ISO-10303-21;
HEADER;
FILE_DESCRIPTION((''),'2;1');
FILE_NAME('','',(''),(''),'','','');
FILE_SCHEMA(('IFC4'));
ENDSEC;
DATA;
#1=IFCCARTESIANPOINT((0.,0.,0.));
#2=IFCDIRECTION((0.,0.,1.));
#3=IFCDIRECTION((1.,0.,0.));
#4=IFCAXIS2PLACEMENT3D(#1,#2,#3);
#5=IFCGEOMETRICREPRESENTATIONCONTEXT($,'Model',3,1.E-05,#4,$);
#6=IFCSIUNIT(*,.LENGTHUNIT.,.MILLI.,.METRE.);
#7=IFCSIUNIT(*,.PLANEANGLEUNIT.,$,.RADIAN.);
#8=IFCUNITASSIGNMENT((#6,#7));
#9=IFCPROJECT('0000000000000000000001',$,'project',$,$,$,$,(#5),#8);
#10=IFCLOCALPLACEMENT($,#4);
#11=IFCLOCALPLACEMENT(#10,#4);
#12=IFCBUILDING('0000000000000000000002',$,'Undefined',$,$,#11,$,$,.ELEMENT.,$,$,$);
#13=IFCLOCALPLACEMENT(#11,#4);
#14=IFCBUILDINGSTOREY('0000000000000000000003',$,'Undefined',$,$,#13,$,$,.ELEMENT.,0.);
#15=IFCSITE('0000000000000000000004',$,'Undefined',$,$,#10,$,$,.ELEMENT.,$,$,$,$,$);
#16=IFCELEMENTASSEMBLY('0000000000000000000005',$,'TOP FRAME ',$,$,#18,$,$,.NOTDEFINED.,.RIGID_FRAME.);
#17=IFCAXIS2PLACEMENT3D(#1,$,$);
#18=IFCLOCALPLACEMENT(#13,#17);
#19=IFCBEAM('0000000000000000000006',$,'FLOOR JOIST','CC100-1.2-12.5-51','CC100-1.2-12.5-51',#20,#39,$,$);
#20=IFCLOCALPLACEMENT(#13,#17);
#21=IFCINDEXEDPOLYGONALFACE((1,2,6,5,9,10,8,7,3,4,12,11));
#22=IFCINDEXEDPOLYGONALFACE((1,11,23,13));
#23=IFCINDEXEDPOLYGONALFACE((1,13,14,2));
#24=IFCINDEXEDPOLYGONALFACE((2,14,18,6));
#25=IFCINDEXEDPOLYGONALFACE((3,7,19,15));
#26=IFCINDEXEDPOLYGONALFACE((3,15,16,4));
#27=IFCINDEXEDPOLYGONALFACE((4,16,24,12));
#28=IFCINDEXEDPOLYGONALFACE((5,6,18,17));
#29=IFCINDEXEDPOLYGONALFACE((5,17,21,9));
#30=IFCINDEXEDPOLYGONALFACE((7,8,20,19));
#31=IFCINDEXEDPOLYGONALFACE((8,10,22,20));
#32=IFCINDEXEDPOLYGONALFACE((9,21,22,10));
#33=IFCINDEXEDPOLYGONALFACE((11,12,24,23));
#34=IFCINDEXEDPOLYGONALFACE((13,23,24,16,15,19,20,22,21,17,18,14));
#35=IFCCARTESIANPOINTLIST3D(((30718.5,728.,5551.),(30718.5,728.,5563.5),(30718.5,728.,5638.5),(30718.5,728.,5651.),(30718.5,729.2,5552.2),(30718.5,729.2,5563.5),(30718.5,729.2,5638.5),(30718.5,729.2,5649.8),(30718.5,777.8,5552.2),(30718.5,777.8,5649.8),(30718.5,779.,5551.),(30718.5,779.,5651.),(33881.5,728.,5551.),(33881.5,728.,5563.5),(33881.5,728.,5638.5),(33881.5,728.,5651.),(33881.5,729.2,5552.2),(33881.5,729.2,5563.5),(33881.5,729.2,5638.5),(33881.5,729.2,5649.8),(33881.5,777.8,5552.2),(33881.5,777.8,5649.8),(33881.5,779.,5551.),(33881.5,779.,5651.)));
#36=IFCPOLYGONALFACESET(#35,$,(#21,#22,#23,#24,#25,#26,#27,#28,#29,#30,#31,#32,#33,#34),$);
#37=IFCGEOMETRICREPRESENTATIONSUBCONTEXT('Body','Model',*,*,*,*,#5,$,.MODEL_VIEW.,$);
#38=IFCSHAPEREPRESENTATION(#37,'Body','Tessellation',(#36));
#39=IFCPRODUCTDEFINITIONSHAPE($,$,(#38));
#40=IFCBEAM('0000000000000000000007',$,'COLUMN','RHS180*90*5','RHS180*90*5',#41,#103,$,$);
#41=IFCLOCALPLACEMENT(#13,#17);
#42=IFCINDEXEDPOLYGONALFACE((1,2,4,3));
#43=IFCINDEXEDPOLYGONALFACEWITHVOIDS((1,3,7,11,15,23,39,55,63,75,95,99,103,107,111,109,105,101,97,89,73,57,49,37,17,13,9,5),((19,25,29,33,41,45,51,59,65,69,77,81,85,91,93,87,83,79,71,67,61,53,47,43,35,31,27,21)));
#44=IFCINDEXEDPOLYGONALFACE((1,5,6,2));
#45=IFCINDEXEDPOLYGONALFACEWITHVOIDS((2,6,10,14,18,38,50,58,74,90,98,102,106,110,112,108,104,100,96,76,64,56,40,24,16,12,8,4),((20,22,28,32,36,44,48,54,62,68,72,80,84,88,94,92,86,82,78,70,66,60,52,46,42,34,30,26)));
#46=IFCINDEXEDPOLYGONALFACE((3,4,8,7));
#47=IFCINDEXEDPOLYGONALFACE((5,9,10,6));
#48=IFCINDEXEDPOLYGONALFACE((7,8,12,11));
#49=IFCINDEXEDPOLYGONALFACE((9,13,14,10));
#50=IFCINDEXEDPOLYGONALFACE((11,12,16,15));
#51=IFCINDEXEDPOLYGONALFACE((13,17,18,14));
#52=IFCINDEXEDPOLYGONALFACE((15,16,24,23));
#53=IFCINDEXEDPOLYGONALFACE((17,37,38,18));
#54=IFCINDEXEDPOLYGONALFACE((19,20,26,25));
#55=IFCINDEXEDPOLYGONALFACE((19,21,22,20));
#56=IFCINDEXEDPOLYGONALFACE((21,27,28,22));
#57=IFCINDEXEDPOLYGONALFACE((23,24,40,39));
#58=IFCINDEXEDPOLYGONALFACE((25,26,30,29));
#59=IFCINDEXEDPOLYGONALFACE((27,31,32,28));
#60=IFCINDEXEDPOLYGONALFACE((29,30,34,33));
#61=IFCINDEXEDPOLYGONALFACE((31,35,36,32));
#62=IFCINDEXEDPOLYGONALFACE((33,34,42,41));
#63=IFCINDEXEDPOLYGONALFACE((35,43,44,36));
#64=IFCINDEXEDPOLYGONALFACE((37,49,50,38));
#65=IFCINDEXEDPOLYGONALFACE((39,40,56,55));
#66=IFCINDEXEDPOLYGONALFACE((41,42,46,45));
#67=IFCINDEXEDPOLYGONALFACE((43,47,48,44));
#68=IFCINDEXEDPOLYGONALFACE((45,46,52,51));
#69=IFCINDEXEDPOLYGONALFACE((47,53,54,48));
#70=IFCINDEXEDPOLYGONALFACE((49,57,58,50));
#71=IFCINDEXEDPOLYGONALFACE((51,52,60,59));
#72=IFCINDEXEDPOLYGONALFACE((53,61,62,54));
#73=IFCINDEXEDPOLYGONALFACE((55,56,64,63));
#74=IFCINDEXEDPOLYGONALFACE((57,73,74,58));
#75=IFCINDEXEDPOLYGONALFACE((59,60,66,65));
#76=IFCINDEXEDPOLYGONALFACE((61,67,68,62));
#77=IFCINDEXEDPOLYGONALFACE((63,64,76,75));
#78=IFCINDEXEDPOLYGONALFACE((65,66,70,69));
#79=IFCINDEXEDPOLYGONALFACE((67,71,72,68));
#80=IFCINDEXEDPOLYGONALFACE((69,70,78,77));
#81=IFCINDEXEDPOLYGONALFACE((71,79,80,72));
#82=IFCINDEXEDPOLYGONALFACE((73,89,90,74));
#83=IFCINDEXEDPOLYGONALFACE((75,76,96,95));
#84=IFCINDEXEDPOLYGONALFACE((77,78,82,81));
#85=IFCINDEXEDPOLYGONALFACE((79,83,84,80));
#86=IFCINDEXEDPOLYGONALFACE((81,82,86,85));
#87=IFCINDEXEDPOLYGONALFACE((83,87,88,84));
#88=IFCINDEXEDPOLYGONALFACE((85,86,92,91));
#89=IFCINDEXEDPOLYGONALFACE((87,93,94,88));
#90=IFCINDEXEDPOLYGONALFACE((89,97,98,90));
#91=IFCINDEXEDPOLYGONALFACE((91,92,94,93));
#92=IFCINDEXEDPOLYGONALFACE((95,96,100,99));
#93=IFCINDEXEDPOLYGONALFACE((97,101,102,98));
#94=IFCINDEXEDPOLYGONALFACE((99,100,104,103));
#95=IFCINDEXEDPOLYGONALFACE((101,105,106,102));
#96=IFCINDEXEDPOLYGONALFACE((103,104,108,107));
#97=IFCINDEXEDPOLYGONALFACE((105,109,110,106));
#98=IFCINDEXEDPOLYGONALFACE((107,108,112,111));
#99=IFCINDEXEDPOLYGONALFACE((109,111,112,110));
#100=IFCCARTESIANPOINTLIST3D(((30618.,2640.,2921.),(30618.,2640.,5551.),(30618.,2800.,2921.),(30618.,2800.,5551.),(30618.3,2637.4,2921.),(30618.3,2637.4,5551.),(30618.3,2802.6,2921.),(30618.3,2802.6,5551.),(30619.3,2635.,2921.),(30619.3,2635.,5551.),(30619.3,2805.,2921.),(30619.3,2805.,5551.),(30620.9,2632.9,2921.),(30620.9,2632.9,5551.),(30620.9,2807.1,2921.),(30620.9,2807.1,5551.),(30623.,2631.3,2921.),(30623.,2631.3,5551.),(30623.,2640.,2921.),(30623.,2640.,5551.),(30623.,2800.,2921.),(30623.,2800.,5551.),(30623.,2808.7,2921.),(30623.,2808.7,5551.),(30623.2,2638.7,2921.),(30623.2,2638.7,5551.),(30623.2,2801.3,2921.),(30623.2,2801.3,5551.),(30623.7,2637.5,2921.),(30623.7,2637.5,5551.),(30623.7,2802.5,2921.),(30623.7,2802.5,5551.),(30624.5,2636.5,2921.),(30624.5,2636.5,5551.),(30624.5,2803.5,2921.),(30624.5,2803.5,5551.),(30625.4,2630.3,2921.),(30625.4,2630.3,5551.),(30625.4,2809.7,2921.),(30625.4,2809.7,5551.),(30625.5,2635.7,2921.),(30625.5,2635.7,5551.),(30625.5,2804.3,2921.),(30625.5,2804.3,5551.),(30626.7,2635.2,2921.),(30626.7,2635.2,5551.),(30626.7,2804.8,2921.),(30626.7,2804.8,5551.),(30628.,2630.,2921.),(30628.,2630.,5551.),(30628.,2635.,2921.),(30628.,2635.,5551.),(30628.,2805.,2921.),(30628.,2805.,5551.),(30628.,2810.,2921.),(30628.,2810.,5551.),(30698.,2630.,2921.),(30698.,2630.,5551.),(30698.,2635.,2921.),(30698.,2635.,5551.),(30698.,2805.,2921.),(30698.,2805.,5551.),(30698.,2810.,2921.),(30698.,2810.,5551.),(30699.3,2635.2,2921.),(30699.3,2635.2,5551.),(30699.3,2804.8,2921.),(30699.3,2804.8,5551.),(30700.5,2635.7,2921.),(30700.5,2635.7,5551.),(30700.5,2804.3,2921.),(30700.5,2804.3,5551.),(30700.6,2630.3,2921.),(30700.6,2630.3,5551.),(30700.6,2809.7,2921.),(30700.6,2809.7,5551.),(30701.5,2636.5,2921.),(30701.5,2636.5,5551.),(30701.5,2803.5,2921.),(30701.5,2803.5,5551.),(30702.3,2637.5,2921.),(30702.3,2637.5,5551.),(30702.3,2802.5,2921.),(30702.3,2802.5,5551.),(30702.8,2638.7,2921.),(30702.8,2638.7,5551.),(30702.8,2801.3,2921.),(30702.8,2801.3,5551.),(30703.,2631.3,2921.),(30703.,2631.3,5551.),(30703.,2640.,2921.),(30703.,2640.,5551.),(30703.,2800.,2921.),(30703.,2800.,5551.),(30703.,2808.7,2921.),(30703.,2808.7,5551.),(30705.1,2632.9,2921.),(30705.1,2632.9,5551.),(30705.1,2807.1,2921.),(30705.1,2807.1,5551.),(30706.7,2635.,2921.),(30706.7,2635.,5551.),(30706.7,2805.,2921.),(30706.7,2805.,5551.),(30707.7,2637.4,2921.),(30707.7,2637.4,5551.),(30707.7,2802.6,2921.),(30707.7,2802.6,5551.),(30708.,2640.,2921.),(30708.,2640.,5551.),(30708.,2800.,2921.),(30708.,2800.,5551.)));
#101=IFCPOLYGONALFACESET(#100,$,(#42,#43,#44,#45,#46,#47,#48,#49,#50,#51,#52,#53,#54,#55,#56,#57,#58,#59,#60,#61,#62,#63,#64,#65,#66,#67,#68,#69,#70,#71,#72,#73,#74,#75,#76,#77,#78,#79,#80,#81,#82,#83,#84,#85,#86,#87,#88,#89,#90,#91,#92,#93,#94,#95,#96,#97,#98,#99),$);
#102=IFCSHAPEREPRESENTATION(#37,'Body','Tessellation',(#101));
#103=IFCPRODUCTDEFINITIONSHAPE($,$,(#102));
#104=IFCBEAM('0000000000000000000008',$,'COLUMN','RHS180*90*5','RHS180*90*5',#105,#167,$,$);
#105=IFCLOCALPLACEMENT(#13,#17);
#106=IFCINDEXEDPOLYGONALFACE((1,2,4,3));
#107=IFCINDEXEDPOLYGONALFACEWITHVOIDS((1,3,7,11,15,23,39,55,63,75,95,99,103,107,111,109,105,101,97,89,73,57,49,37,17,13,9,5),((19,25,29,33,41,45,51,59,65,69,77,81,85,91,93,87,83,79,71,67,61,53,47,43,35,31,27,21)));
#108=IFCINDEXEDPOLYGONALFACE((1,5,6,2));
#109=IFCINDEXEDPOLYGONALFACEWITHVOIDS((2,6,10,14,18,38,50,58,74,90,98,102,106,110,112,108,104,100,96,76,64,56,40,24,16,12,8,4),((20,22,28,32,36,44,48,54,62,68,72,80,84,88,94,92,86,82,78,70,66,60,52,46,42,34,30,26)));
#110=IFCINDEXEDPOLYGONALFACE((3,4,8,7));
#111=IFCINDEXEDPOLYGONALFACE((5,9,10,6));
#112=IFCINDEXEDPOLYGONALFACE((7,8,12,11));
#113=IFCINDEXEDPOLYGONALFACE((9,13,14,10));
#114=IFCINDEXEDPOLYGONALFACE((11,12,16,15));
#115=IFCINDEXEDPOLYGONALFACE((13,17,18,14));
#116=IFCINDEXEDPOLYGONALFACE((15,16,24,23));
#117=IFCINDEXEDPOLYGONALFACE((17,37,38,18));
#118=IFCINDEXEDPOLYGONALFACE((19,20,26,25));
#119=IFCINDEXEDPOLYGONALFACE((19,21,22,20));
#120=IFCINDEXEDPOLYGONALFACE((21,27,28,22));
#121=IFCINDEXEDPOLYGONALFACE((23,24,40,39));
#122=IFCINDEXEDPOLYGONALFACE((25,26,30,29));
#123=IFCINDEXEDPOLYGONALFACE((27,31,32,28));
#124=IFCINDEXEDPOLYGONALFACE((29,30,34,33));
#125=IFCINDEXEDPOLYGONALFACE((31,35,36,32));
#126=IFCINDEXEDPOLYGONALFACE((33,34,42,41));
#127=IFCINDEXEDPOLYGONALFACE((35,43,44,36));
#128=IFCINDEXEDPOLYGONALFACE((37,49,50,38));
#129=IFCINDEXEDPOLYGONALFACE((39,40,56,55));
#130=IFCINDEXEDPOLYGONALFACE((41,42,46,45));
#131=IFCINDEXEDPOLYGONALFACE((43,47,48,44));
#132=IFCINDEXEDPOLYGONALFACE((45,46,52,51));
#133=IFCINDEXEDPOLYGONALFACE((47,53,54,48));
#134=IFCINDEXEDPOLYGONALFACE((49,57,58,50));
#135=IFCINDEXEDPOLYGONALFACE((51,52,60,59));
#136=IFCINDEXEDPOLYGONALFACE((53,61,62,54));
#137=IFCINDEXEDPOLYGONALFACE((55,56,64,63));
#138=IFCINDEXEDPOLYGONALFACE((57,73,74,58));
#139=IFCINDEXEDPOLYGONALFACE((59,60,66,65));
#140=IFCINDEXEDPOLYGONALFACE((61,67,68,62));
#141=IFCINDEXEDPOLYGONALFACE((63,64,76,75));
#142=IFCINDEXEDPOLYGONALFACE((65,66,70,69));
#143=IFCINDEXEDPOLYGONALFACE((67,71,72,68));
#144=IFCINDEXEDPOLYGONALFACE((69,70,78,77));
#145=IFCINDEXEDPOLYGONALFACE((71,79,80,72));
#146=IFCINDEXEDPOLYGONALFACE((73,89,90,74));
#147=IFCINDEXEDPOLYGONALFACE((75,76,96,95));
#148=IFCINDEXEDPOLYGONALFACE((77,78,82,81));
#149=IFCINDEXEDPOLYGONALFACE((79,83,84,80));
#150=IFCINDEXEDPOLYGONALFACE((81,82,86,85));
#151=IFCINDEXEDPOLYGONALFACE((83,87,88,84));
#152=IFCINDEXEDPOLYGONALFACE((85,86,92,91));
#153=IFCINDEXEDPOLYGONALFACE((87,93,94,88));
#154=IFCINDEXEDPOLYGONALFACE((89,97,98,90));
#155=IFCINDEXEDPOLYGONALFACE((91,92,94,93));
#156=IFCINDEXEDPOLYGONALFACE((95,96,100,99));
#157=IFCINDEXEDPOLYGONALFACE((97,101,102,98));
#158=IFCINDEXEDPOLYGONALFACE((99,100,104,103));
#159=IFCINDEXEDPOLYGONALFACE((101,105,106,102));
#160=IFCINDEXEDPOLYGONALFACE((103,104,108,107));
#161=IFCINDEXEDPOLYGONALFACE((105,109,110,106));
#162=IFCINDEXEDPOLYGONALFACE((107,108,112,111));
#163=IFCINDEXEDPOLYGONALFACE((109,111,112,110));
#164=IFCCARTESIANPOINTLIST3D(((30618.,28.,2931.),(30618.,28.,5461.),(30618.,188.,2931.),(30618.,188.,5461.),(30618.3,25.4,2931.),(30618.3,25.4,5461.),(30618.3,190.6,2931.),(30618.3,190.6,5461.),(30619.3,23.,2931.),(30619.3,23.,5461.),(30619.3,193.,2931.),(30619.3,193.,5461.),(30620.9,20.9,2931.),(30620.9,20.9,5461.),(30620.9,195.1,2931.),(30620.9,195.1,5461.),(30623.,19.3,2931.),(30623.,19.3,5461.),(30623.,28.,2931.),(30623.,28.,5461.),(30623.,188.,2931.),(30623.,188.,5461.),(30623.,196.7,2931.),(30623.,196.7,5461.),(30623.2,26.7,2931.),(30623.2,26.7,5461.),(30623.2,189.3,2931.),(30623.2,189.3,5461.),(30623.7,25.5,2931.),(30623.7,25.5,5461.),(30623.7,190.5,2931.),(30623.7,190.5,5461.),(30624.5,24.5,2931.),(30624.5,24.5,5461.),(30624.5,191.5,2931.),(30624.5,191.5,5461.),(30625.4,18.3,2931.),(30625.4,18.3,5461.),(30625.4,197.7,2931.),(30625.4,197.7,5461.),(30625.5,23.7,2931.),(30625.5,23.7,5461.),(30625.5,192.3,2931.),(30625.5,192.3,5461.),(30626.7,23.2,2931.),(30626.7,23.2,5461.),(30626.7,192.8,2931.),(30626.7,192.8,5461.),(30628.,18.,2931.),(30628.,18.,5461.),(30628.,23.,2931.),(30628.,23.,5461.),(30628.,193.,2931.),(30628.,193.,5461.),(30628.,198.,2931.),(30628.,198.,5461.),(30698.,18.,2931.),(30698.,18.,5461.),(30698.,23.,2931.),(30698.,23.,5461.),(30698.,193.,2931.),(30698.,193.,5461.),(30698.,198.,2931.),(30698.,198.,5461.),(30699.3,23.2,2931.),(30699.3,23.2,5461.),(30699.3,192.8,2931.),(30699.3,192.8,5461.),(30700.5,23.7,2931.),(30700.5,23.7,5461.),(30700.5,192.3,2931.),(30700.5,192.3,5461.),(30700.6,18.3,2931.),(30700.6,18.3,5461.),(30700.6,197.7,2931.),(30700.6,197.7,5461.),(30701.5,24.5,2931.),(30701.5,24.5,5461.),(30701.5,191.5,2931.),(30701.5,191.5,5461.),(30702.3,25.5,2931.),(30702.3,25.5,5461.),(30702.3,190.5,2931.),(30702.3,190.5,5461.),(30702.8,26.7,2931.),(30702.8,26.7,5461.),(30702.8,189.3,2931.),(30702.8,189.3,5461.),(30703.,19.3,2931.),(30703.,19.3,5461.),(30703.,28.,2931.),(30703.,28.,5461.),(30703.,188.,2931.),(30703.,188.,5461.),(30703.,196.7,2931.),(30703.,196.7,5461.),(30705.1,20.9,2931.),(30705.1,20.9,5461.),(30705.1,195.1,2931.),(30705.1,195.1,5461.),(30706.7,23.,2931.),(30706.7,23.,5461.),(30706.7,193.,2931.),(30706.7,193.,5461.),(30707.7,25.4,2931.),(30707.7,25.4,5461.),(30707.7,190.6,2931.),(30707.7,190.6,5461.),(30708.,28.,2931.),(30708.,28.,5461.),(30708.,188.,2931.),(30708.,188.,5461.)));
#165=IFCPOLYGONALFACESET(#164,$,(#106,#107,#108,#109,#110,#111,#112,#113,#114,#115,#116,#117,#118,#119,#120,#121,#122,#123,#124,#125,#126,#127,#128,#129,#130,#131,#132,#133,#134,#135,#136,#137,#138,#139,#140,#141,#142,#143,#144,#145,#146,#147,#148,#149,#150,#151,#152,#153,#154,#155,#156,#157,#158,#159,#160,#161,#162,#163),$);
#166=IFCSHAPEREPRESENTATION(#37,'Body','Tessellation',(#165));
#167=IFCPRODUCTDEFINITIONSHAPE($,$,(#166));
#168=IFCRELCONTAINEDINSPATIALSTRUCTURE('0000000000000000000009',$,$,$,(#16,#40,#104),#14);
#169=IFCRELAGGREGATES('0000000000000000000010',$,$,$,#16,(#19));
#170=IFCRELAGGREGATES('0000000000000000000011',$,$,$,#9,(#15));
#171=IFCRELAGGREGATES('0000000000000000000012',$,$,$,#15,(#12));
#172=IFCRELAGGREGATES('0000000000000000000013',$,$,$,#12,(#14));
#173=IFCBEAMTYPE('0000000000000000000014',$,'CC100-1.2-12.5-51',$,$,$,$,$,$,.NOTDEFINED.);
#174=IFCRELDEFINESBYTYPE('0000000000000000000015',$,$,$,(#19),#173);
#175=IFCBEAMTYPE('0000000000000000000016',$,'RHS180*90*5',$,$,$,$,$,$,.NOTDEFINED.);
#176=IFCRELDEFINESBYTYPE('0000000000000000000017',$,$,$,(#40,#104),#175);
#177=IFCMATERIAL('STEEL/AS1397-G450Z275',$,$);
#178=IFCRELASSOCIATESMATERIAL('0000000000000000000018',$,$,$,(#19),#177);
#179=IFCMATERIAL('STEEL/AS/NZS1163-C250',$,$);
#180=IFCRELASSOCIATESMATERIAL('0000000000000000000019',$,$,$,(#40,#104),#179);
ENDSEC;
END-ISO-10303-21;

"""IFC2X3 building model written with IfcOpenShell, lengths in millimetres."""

from ifc_helpers import new_model, si_unit, frame, origin_with_axes, origin_2d_with_axis, place, context, subcontext, project, spatial, hollow_rectangle, c_section, extrude, material, type_object, element, aggregate, save


model = new_model("IFC2X3")

# Units and contexts
model_context = context("Model", 3, precision=1e-05, world=origin_with_axes())
body_context = subcontext(model_context, "Body", "Model", "MODEL_VIEW")
ifc_project = project(units=[si_unit("LENGTHUNIT", "METRE", prefix="MILLI"), si_unit("PLANEANGLEUNIT", "RADIAN")], contexts=[model_context])

# Site, building, storey
site_placement = place(None, origin_with_axes())
site = spatial("IfcSite", under=ifc_project, at=site_placement, Name="Undefined", CompositionType="ELEMENT")
building_placement = place(site_placement, origin_with_axes())
building = spatial("IfcBuilding", under=site, at=building_placement, Name="Undefined", CompositionType="ELEMENT")
storey_placement = place(building_placement, origin_with_axes())
storey = spatial("IfcBuildingStorey", under=building, at=storey_placement, Name="Undefined", CompositionType="ELEMENT", Elevation=0.0)

# Element assembly, beam
ifc_material_1 = material(Name="STEEL/AS1397-G450Z275")
ifc_material_2 = material(Name="STEEL/AS/NZS1163-C250")
beam_type_1 = type_object("IfcBeamType", Name="CC100-1.2-12.5-51", PredefinedType="NOTDEFINED")
assembly_1_placement = place(storey_placement, origin_with_axes())
assembly_1 = element("IfcElementAssembly", 1, at=assembly_1_placement, inside=storey, Name="TOP FRAME ", AssemblyPlace="NOTDEFINED", PredefinedType="RIGID_FRAME")
beam_1_placement = place(assembly_1_placement, frame((30718.5, 753.5, 5601.0), z_axis=(0.0, 0.0, 1.0), x_axis=(1.0, 0.0, 0.0)))
beam_1 = element("IfcBeam", 2, at=beam_1_placement, type_object=beam_type_1, material=ifc_material_1, Name="FLOOR JOIST", Description="CC100-1.2-12.5-51", ObjectType="CC100-1.2-12.5-51", context=body_context, shape_type="SweptSolid", body=[
    extrude(c_section(Depth=100.0, Width=51.0, WallThickness=1.2, Girth=12.5, at=origin_2d_with_axis()), frame((3163.0, 0.0, 0.0), z_axis=(-1.0, 0.0, 0.0), x_axis=(0.0, -1.0, 0.0)), (0.0, 0.0, 1.0), 3163.0),
])
aggregate(assembly_1, [beam_1])

# Beams
beam_type_2 = type_object("IfcBeamType", Name="RHS180*90*5", PredefinedType="NOTDEFINED")
beam_2_placement = place(storey_placement, frame((30663.0, 2720.0, 5551.0), z_axis=(0.0, 1.0, 0.0), x_axis=(0.0, 0.0, -1.0)))
element("IfcBeam", 3, at=beam_2_placement, inside=storey, type_object=beam_type_2, material=ifc_material_2, Name="COLUMN", Description="RHS180*90*5", ObjectType="RHS180*90*5", context=body_context, shape_type="SweptSolid", body=[
    extrude(hollow_rectangle(XDim=90.0, YDim=180.0, WallThickness=5.0, InnerFilletRadius=5.0, OuterFilletRadius=10.0, at=origin_2d_with_axis()), frame((2630.0, 0.0, 0.0), z_axis=(-1.0, 0.0, 0.0), x_axis=(0.0, -1.0, 0.0)), (0.0, 0.0, 1.0), 2630.0),
])
beam_3_placement = place(storey_placement, frame((30663.0, 108.0, 5461.0), z_axis=(0.0, 1.0, 0.0), x_axis=(0.0, 0.0, -1.0)))
element("IfcBeam", 4, at=beam_3_placement, inside=storey, type_object=beam_type_2, material=ifc_material_2, Name="COLUMN", Description="RHS180*90*5", ObjectType="RHS180*90*5", context=body_context, shape_type="SweptSolid", body=[
    extrude(hollow_rectangle(XDim=90.0, YDim=180.0, WallThickness=5.0, InnerFilletRadius=5.0, OuterFilletRadius=10.0, at=origin_2d_with_axis()), frame((2530.0, 0.0, 0.0), z_axis=(-1.0, 0.0, 0.0), x_axis=(0.0, -1.0, 0.0)), (0.0, 0.0, 1.0), 2530.0),
])

save(model, "model.ifc")
